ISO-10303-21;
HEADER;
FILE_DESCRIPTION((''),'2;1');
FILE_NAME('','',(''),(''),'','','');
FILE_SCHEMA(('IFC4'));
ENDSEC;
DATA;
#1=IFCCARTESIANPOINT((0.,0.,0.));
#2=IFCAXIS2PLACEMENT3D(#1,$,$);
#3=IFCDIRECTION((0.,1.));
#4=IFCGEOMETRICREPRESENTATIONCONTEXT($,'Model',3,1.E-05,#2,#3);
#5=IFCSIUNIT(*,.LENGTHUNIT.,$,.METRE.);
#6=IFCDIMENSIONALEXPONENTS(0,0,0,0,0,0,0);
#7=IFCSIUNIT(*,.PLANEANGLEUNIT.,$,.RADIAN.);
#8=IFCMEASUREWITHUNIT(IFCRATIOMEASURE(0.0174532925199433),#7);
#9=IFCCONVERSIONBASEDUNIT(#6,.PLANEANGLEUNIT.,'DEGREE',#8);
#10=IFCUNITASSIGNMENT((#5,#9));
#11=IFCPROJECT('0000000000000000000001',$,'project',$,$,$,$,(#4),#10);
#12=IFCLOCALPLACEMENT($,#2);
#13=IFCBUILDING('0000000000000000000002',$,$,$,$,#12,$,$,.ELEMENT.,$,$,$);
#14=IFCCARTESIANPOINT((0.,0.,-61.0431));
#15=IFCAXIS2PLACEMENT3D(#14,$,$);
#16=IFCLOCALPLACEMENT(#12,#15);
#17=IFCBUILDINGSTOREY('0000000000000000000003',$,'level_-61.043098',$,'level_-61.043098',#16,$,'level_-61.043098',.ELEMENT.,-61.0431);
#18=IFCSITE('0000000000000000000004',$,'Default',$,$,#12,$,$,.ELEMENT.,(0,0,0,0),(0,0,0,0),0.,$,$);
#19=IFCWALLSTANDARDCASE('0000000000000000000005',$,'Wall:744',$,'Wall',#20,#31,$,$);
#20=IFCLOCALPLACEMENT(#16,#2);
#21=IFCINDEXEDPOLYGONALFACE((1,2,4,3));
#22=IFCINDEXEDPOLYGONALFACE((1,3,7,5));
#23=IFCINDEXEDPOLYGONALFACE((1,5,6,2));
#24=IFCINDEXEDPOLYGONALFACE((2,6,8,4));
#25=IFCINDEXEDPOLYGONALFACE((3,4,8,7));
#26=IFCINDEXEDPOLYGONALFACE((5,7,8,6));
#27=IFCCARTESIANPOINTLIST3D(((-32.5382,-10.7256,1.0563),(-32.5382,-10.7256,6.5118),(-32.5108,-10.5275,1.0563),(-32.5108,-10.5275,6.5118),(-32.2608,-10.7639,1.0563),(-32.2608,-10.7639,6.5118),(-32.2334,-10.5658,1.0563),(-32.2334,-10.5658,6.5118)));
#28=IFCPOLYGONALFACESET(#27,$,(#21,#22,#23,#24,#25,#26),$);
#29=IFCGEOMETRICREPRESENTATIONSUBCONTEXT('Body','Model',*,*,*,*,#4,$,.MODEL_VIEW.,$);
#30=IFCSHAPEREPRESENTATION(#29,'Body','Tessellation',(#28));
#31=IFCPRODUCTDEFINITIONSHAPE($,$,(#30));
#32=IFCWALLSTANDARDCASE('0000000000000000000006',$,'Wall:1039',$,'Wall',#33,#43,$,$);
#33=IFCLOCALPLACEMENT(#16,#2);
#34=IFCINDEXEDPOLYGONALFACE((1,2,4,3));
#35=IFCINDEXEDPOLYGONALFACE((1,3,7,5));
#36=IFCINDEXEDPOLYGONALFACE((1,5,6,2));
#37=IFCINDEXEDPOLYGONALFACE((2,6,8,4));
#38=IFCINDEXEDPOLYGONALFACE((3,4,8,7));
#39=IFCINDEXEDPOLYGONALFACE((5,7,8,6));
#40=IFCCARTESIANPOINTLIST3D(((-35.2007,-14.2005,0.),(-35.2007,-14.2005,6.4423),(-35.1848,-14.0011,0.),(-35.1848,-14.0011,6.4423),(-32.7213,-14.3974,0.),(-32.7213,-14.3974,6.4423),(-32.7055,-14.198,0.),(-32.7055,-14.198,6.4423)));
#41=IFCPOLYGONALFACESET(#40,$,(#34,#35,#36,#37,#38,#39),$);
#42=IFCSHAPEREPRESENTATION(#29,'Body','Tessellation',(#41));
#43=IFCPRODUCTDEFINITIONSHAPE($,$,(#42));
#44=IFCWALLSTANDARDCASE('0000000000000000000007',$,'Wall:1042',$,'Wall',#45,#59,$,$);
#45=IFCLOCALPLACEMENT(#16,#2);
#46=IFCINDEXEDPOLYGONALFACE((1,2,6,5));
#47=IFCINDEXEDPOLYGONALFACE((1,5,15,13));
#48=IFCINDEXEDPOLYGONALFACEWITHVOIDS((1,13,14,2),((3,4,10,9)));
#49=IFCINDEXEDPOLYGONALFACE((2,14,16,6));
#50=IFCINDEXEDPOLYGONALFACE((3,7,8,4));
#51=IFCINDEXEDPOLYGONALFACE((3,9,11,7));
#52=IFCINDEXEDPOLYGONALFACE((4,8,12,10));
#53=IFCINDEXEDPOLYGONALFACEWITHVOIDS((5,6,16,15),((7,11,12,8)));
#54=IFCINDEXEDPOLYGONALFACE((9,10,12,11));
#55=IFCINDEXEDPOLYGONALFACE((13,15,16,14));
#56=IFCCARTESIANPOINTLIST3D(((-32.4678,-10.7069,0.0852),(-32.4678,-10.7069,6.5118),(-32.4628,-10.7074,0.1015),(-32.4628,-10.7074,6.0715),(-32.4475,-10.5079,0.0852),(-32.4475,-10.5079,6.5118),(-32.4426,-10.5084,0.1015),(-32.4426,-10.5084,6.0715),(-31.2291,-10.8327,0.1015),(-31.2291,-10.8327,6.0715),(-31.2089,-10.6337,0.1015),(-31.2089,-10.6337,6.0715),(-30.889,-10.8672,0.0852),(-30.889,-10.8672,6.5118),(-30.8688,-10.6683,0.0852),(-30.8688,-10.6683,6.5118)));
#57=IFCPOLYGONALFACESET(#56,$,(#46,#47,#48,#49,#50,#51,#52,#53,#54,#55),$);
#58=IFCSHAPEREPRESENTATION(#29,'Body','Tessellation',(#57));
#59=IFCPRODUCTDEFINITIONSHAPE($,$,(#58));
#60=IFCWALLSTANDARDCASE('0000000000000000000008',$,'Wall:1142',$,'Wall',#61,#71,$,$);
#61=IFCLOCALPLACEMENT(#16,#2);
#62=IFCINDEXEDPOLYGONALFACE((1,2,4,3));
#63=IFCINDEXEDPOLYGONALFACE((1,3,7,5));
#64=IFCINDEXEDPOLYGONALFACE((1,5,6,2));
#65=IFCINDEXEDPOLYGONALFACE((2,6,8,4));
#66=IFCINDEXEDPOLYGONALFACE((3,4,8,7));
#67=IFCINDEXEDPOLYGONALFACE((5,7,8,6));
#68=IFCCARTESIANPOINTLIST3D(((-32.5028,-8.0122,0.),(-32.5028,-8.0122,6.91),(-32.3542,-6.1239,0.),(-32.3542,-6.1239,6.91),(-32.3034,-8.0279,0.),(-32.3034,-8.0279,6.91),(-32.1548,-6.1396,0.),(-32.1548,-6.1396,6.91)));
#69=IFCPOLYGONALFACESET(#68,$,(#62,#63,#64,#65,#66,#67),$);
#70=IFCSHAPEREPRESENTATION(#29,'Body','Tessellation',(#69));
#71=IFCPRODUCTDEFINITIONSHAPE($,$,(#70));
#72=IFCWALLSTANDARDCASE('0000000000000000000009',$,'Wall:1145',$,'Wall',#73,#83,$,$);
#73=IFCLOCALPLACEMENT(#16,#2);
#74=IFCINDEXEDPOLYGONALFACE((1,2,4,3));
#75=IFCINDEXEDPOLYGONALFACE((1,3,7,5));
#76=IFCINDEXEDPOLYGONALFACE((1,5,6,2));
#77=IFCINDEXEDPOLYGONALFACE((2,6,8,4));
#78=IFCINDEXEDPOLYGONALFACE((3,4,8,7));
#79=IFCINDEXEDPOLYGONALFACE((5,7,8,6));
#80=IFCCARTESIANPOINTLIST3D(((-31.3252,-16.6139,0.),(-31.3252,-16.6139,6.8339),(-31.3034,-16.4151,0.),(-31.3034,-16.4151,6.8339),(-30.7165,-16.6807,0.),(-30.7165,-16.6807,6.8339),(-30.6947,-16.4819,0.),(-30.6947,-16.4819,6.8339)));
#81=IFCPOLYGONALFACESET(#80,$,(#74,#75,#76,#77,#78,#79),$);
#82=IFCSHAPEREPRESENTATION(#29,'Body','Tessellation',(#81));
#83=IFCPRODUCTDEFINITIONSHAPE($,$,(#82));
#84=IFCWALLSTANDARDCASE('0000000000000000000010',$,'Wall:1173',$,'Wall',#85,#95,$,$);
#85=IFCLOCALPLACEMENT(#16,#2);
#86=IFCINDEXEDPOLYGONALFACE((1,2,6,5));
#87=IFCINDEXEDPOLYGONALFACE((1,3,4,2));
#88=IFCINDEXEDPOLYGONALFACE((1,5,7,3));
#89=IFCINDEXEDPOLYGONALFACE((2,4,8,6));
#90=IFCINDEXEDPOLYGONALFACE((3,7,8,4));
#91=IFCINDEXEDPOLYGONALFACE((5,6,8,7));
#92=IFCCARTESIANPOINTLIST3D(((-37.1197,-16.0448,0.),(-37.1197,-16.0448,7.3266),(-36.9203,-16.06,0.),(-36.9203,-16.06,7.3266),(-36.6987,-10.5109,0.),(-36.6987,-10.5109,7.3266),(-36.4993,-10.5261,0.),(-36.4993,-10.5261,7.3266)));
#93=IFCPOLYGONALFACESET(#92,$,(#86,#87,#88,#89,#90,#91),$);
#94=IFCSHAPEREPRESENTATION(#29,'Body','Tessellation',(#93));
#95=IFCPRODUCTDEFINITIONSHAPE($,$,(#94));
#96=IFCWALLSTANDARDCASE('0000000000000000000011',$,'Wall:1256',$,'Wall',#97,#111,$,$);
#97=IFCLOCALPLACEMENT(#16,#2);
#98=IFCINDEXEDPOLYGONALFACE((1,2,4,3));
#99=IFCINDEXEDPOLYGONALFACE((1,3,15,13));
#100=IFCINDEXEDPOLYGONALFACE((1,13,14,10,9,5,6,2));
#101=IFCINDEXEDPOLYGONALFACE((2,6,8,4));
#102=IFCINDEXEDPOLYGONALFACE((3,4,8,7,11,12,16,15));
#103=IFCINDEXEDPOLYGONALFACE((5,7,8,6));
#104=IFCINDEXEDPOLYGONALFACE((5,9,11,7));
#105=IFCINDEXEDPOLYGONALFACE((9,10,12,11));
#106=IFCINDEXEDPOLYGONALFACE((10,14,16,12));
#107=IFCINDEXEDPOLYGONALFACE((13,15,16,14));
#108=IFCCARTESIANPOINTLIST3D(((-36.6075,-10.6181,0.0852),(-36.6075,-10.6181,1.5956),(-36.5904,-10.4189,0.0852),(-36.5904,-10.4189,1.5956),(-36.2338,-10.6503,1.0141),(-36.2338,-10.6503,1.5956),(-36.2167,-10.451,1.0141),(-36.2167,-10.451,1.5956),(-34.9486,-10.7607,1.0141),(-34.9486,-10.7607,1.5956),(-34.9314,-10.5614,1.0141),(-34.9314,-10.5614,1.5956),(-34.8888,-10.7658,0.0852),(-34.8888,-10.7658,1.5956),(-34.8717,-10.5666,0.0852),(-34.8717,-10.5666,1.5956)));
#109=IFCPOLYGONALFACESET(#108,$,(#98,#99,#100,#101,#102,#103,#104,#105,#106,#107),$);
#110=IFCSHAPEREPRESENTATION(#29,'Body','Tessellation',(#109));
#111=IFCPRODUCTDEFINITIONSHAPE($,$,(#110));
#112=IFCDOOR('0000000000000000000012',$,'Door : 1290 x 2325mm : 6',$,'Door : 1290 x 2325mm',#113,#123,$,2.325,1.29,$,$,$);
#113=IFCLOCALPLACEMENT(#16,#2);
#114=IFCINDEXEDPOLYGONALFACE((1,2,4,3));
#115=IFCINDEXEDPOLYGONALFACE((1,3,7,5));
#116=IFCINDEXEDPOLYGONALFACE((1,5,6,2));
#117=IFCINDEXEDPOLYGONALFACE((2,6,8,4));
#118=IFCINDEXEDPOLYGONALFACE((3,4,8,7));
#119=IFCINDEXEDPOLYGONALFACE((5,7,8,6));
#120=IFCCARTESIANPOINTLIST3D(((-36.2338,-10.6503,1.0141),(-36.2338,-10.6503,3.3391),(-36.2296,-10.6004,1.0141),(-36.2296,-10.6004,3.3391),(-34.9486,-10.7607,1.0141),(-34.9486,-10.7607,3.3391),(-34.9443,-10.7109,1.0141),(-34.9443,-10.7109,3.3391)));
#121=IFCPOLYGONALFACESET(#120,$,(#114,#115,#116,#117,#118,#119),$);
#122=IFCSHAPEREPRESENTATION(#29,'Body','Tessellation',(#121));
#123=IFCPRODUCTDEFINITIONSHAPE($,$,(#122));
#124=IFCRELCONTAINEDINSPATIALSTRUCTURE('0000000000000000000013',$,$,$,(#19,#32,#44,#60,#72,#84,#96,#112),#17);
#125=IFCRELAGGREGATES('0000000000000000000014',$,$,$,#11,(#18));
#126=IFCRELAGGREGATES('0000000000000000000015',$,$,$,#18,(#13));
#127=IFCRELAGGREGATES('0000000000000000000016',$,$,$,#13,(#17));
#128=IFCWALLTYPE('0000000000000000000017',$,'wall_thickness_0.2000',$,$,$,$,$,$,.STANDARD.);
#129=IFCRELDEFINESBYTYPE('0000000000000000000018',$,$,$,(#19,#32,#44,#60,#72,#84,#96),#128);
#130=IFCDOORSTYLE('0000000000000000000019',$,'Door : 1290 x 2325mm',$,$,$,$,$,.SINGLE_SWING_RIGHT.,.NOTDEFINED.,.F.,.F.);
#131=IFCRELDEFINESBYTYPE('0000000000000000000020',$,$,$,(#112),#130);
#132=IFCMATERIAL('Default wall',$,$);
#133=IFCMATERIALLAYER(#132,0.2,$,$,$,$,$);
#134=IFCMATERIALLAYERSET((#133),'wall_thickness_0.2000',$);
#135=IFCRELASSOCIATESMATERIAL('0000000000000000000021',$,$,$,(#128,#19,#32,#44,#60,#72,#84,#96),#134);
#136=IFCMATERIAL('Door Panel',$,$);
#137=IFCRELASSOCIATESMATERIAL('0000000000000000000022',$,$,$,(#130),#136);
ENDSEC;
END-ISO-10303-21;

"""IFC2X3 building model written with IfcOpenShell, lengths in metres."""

from ifc_helpers import new_model, entity, si_unit, converted_unit, direction, frame, frame_2d, origin, origin_2d_with_axis, place, context, subcontext, project, spatial, polyline, rectangle, outline, extrude, source, transform, mapped, material, layer, layer_set, layer_usage, type_object, type_shapes, element, fill, save


model = new_model("IFC2X3")

# Units and contexts
model_context = context("Model", 3, precision=1e-05, world=origin(), true_north=direction((0.0, 1.0)))
body_context = subcontext(model_context, "Body", "Model", "MODEL_VIEW")
ifc_project = project(units=[si_unit("LENGTHUNIT", "METRE"), converted_unit("PLANEANGLEUNIT", "DEGREE", entity("IfcRatioMeasure", 0.0174532925199433), si_unit("PLANEANGLEUNIT", "RADIAN"), dimensions=[0, 0, 0, 0, 0, 0, 0])], contexts=[model_context])

# Site, building, storey
placement_1 = place(None, origin())
site = spatial("IfcSite", under=ifc_project, at=placement_1, Name="Default", CompositionType="ELEMENT", RefLatitude=(0, 0, 0, 0), RefLongitude=(0, 0, 0, 0), RefElevation=0.0)
building = spatial("IfcBuilding", under=site, at=placement_1, CompositionType="ELEMENT")
storey_placement = place(placement_1, frame((0.0, 0.0, -61.0431)))
storey = spatial("IfcBuildingStorey", under=building, at=storey_placement, Name="level_-61.043098", ObjectType="level_-61.043098", LongName="level_-61.043098", CompositionType="ELEMENT", Elevation=-61.0431)

# Shared definitions
ifc_material_1 = material(Name="Default wall")
ifc_layer = layer(ifc_material_1, 0.2)
ifc_layer_set = layer_set([ifc_layer], Name="wall_thickness_0.2000")
ifc_layer_usage = layer_usage(ifc_layer_set, "AXIS2", "POSITIVE", -0.1)
wall_type = type_object("IfcWallType", Name="wall_thickness_0.2000", PredefinedType="STANDARD", material=ifc_layer_set)

# Walls
placement_2 = place(placement_1, frame((0.0, 0.0, -59.9868)))
wall_1_placement = place(placement_2, frame((-32.2471, -10.6648, 0.0), z_axis=(0.0, 0.0, 1.0), x_axis=(-0.990596, 0.136822, 0.0)))
element("IfcWallStandardCase", 1, at=wall_1_placement, inside=storey, type_object=wall_type, material=ifc_layer_usage, Name="Wall:744", ObjectType="Wall", context=body_context, shape_type="SweptSolid", body=[
    extrude(outline(polyline([(0.28, -0.1), (0.28, 0.1), (0.0, 0.1), (0.0, -0.1), (0.28, -0.1)])), origin(), (0.0, 0.0, 1.0), 5.4555),
])
wall_2_placement = place(storey_placement, frame((-32.7134, -14.2977, 0.0), z_axis=(0.0, 0.0, 1.0), x_axis=(-0.99686, 0.079182, 0.0)))
element("IfcWallStandardCase", 2, at=wall_2_placement, inside=storey, type_object=wall_type, material=ifc_layer_usage, Name="Wall:1039", ObjectType="Wall", context=body_context, shape_type="SweptSolid", body=[
    extrude(outline(polyline([(2.4872, -0.1), (2.4872, 0.1), (0.0, 0.1), (0.0, -0.1), (2.4872, -0.1)])), origin(), (0.0, 0.0, 1.0), 6.4423),
])

# Wall, opening
placement_3 = place(placement_1, frame((0.0, 0.0, -60.9579)))
wall_3_placement = place(placement_3, frame((-30.8789, -10.7678, 0.0), z_axis=(0.0, 0.0, 1.0), x_axis=(-0.994879, 0.10107, 0.0)))
wall_3 = element("IfcWallStandardCase", 3, at=wall_3_placement, inside=storey, type_object=wall_type, material=ifc_layer_usage, Name="Wall:1042", ObjectType="Wall", context=body_context, shape_type="SweptSolid", body=[
    extrude(outline(polyline([(1.5869, -0.1), (1.5869, 0.1), (0.0, 0.1), (0.0, -0.1), (1.5869, -0.1)])), origin(), (0.0, 0.0, 1.0), 6.4266),
])
opening_1_placement = place(wall_3_placement, frame((0.3419, -0.1, 0.0163)))
element("IfcOpeningElement", 4, at=opening_1_placement, cuts=wall_3, ObjectType="Opening", context=body_context, shape_type="SweptSolid", body=[
    extrude(rectangle(XDim=1.24, YDim=5.97, at=frame_2d((2.985, 0.62), x_axis=(0.0, 1.0))), frame((0.0, 0.0, 0.0), z_axis=(0.0, 1.0, 0.0), x_axis=(0.0, 0.0, 1.0)), (0.0, 0.0, 1.0), 0.2),
])

# Walls
wall_4_placement = place(storey_placement, frame((-32.2545, -6.1318, 0.0), z_axis=(0.0, 0.0, 1.0), x_axis=(-0.078428, -0.99692, 0.0)))
element("IfcWallStandardCase", 5, at=wall_4_placement, inside=storey, type_object=wall_type, material=ifc_layer_usage, Name="Wall:1142", ObjectType="Wall", context=body_context, shape_type="SweptSolid", body=[
    extrude(outline(polyline([(1.8941, -0.1), (1.8941, 0.1), (0.0, 0.1), (0.0, -0.1), (1.8941, -0.1)])), origin(), (0.0, 0.0, 1.0), 6.91),
])
wall_5_placement = place(storey_placement, frame((-30.7056, -16.5813, 0.0), z_axis=(0.0, 0.0, 1.0), x_axis=(-0.994031, 0.109095, 0.0)))
element("IfcWallStandardCase", 6, at=wall_5_placement, inside=storey, type_object=wall_type, material=ifc_layer_usage, Name="Wall:1145", ObjectType="Wall", context=body_context, shape_type="SweptSolid", body=[
    extrude(outline(polyline([(0.6124, -0.1), (0.6124, 0.1), (0.0, 0.1), (0.0, -0.1), (0.6124, -0.1)])), origin(), (0.0, 0.0, 1.0), 6.8339),
])
wall_6_placement = place(storey_placement, frame((-36.599, -10.5185, 0.0), z_axis=(0.0, 0.0, 1.0), x_axis=(-0.075868, -0.997118, 0.0)))
element("IfcWallStandardCase", 7, at=wall_6_placement, inside=storey, type_object=wall_type, material=ifc_layer_usage, Name="Wall:1173", ObjectType="Wall", context=body_context, shape_type="SweptSolid", body=[
    extrude(outline(polyline([(5.5499, -0.1), (5.5499, 0.1), (0.0, 0.1), (0.0, -0.1), (5.5499, -0.1)])), origin(), (0.0, 0.0, 1.0), 7.3266),
])

# Wall, opening, door
placement_4 = place(placement_1, frame((0.0, 0.0, -60.9579)))
wall_7_placement = place(placement_4, frame((-34.8802, -10.6662, 0.0), z_axis=(0.0, 0.0, 1.0), x_axis=(-0.996328, 0.085616, 0.0)))
wall_7 = element("IfcWallStandardCase", 8, at=wall_7_placement, inside=storey, type_object=wall_type, material=ifc_layer_usage, Name="Wall:1256", ObjectType="Wall", context=body_context, shape_type="SweptSolid", body=[
    extrude(outline(polyline([(1.7251, -0.1), (1.7251, 0.1), (0.0, 0.1), (0.0, -0.1), (1.7251, -0.1)])), origin(), (0.0, 0.0, 1.0), 1.5104),
])
opening_2_placement = place(wall_7_placement, frame((0.06, -0.1, 0.9289)))
opening_2 = element("IfcOpeningElement", 9, at=opening_2_placement, cuts=wall_7, ObjectType="Opening", context=body_context, shape_type="SweptSolid", body=[
    extrude(rectangle(XDim=1.29, YDim=2.325, at=frame_2d((1.1625, 0.645), x_axis=(0.0, 1.0))), frame((0.0, 0.0, 0.0), z_axis=(0.0, 1.0, 0.0), x_axis=(0.0, 0.0, 1.0)), (0.0, 0.0, 1.0), 0.2),
])
ifc_material_2 = material(Name="Door Panel")
door_style = type_object("IfcDoorStyle", Name="Door : 1290 x 2325mm", ConstructionType="NOTDEFINED", OperationType="SINGLE_SWING_RIGHT", ParameterTakesPrecedence=False, Sizeable=False, material=ifc_material_2)
shared_shape_1 = source(origin(), body_context, "Body", "SweptSolid", [
    extrude(rectangle(XDim=0.05, YDim=1.29, at=origin_2d_with_axis()), frame((0.645, 0.175, 0.0), z_axis=(0.0, 0.0, 1.0), x_axis=(0.0, 1.0, 0.0)), (0.0, 0.0, 1.0), 2.325),
])
type_shapes(door_style, [shared_shape_1])
door_placement = place(opening_2_placement, origin())
door = element("IfcDoor", 10, at=door_placement, inside=storey, type_object=door_style, Name="Door : 1290 x 2325mm : 6", ObjectType="Door : 1290 x 2325mm", OverallHeight=2.325, OverallWidth=1.29, context=body_context, shape_type="MappedRepresentation", body=[
    mapped(shared_shape_1, transform((0.0, 0.0, 0.0), scale=1.0)),
])
fill(opening_2, door)

save(model, "model.ifc")
